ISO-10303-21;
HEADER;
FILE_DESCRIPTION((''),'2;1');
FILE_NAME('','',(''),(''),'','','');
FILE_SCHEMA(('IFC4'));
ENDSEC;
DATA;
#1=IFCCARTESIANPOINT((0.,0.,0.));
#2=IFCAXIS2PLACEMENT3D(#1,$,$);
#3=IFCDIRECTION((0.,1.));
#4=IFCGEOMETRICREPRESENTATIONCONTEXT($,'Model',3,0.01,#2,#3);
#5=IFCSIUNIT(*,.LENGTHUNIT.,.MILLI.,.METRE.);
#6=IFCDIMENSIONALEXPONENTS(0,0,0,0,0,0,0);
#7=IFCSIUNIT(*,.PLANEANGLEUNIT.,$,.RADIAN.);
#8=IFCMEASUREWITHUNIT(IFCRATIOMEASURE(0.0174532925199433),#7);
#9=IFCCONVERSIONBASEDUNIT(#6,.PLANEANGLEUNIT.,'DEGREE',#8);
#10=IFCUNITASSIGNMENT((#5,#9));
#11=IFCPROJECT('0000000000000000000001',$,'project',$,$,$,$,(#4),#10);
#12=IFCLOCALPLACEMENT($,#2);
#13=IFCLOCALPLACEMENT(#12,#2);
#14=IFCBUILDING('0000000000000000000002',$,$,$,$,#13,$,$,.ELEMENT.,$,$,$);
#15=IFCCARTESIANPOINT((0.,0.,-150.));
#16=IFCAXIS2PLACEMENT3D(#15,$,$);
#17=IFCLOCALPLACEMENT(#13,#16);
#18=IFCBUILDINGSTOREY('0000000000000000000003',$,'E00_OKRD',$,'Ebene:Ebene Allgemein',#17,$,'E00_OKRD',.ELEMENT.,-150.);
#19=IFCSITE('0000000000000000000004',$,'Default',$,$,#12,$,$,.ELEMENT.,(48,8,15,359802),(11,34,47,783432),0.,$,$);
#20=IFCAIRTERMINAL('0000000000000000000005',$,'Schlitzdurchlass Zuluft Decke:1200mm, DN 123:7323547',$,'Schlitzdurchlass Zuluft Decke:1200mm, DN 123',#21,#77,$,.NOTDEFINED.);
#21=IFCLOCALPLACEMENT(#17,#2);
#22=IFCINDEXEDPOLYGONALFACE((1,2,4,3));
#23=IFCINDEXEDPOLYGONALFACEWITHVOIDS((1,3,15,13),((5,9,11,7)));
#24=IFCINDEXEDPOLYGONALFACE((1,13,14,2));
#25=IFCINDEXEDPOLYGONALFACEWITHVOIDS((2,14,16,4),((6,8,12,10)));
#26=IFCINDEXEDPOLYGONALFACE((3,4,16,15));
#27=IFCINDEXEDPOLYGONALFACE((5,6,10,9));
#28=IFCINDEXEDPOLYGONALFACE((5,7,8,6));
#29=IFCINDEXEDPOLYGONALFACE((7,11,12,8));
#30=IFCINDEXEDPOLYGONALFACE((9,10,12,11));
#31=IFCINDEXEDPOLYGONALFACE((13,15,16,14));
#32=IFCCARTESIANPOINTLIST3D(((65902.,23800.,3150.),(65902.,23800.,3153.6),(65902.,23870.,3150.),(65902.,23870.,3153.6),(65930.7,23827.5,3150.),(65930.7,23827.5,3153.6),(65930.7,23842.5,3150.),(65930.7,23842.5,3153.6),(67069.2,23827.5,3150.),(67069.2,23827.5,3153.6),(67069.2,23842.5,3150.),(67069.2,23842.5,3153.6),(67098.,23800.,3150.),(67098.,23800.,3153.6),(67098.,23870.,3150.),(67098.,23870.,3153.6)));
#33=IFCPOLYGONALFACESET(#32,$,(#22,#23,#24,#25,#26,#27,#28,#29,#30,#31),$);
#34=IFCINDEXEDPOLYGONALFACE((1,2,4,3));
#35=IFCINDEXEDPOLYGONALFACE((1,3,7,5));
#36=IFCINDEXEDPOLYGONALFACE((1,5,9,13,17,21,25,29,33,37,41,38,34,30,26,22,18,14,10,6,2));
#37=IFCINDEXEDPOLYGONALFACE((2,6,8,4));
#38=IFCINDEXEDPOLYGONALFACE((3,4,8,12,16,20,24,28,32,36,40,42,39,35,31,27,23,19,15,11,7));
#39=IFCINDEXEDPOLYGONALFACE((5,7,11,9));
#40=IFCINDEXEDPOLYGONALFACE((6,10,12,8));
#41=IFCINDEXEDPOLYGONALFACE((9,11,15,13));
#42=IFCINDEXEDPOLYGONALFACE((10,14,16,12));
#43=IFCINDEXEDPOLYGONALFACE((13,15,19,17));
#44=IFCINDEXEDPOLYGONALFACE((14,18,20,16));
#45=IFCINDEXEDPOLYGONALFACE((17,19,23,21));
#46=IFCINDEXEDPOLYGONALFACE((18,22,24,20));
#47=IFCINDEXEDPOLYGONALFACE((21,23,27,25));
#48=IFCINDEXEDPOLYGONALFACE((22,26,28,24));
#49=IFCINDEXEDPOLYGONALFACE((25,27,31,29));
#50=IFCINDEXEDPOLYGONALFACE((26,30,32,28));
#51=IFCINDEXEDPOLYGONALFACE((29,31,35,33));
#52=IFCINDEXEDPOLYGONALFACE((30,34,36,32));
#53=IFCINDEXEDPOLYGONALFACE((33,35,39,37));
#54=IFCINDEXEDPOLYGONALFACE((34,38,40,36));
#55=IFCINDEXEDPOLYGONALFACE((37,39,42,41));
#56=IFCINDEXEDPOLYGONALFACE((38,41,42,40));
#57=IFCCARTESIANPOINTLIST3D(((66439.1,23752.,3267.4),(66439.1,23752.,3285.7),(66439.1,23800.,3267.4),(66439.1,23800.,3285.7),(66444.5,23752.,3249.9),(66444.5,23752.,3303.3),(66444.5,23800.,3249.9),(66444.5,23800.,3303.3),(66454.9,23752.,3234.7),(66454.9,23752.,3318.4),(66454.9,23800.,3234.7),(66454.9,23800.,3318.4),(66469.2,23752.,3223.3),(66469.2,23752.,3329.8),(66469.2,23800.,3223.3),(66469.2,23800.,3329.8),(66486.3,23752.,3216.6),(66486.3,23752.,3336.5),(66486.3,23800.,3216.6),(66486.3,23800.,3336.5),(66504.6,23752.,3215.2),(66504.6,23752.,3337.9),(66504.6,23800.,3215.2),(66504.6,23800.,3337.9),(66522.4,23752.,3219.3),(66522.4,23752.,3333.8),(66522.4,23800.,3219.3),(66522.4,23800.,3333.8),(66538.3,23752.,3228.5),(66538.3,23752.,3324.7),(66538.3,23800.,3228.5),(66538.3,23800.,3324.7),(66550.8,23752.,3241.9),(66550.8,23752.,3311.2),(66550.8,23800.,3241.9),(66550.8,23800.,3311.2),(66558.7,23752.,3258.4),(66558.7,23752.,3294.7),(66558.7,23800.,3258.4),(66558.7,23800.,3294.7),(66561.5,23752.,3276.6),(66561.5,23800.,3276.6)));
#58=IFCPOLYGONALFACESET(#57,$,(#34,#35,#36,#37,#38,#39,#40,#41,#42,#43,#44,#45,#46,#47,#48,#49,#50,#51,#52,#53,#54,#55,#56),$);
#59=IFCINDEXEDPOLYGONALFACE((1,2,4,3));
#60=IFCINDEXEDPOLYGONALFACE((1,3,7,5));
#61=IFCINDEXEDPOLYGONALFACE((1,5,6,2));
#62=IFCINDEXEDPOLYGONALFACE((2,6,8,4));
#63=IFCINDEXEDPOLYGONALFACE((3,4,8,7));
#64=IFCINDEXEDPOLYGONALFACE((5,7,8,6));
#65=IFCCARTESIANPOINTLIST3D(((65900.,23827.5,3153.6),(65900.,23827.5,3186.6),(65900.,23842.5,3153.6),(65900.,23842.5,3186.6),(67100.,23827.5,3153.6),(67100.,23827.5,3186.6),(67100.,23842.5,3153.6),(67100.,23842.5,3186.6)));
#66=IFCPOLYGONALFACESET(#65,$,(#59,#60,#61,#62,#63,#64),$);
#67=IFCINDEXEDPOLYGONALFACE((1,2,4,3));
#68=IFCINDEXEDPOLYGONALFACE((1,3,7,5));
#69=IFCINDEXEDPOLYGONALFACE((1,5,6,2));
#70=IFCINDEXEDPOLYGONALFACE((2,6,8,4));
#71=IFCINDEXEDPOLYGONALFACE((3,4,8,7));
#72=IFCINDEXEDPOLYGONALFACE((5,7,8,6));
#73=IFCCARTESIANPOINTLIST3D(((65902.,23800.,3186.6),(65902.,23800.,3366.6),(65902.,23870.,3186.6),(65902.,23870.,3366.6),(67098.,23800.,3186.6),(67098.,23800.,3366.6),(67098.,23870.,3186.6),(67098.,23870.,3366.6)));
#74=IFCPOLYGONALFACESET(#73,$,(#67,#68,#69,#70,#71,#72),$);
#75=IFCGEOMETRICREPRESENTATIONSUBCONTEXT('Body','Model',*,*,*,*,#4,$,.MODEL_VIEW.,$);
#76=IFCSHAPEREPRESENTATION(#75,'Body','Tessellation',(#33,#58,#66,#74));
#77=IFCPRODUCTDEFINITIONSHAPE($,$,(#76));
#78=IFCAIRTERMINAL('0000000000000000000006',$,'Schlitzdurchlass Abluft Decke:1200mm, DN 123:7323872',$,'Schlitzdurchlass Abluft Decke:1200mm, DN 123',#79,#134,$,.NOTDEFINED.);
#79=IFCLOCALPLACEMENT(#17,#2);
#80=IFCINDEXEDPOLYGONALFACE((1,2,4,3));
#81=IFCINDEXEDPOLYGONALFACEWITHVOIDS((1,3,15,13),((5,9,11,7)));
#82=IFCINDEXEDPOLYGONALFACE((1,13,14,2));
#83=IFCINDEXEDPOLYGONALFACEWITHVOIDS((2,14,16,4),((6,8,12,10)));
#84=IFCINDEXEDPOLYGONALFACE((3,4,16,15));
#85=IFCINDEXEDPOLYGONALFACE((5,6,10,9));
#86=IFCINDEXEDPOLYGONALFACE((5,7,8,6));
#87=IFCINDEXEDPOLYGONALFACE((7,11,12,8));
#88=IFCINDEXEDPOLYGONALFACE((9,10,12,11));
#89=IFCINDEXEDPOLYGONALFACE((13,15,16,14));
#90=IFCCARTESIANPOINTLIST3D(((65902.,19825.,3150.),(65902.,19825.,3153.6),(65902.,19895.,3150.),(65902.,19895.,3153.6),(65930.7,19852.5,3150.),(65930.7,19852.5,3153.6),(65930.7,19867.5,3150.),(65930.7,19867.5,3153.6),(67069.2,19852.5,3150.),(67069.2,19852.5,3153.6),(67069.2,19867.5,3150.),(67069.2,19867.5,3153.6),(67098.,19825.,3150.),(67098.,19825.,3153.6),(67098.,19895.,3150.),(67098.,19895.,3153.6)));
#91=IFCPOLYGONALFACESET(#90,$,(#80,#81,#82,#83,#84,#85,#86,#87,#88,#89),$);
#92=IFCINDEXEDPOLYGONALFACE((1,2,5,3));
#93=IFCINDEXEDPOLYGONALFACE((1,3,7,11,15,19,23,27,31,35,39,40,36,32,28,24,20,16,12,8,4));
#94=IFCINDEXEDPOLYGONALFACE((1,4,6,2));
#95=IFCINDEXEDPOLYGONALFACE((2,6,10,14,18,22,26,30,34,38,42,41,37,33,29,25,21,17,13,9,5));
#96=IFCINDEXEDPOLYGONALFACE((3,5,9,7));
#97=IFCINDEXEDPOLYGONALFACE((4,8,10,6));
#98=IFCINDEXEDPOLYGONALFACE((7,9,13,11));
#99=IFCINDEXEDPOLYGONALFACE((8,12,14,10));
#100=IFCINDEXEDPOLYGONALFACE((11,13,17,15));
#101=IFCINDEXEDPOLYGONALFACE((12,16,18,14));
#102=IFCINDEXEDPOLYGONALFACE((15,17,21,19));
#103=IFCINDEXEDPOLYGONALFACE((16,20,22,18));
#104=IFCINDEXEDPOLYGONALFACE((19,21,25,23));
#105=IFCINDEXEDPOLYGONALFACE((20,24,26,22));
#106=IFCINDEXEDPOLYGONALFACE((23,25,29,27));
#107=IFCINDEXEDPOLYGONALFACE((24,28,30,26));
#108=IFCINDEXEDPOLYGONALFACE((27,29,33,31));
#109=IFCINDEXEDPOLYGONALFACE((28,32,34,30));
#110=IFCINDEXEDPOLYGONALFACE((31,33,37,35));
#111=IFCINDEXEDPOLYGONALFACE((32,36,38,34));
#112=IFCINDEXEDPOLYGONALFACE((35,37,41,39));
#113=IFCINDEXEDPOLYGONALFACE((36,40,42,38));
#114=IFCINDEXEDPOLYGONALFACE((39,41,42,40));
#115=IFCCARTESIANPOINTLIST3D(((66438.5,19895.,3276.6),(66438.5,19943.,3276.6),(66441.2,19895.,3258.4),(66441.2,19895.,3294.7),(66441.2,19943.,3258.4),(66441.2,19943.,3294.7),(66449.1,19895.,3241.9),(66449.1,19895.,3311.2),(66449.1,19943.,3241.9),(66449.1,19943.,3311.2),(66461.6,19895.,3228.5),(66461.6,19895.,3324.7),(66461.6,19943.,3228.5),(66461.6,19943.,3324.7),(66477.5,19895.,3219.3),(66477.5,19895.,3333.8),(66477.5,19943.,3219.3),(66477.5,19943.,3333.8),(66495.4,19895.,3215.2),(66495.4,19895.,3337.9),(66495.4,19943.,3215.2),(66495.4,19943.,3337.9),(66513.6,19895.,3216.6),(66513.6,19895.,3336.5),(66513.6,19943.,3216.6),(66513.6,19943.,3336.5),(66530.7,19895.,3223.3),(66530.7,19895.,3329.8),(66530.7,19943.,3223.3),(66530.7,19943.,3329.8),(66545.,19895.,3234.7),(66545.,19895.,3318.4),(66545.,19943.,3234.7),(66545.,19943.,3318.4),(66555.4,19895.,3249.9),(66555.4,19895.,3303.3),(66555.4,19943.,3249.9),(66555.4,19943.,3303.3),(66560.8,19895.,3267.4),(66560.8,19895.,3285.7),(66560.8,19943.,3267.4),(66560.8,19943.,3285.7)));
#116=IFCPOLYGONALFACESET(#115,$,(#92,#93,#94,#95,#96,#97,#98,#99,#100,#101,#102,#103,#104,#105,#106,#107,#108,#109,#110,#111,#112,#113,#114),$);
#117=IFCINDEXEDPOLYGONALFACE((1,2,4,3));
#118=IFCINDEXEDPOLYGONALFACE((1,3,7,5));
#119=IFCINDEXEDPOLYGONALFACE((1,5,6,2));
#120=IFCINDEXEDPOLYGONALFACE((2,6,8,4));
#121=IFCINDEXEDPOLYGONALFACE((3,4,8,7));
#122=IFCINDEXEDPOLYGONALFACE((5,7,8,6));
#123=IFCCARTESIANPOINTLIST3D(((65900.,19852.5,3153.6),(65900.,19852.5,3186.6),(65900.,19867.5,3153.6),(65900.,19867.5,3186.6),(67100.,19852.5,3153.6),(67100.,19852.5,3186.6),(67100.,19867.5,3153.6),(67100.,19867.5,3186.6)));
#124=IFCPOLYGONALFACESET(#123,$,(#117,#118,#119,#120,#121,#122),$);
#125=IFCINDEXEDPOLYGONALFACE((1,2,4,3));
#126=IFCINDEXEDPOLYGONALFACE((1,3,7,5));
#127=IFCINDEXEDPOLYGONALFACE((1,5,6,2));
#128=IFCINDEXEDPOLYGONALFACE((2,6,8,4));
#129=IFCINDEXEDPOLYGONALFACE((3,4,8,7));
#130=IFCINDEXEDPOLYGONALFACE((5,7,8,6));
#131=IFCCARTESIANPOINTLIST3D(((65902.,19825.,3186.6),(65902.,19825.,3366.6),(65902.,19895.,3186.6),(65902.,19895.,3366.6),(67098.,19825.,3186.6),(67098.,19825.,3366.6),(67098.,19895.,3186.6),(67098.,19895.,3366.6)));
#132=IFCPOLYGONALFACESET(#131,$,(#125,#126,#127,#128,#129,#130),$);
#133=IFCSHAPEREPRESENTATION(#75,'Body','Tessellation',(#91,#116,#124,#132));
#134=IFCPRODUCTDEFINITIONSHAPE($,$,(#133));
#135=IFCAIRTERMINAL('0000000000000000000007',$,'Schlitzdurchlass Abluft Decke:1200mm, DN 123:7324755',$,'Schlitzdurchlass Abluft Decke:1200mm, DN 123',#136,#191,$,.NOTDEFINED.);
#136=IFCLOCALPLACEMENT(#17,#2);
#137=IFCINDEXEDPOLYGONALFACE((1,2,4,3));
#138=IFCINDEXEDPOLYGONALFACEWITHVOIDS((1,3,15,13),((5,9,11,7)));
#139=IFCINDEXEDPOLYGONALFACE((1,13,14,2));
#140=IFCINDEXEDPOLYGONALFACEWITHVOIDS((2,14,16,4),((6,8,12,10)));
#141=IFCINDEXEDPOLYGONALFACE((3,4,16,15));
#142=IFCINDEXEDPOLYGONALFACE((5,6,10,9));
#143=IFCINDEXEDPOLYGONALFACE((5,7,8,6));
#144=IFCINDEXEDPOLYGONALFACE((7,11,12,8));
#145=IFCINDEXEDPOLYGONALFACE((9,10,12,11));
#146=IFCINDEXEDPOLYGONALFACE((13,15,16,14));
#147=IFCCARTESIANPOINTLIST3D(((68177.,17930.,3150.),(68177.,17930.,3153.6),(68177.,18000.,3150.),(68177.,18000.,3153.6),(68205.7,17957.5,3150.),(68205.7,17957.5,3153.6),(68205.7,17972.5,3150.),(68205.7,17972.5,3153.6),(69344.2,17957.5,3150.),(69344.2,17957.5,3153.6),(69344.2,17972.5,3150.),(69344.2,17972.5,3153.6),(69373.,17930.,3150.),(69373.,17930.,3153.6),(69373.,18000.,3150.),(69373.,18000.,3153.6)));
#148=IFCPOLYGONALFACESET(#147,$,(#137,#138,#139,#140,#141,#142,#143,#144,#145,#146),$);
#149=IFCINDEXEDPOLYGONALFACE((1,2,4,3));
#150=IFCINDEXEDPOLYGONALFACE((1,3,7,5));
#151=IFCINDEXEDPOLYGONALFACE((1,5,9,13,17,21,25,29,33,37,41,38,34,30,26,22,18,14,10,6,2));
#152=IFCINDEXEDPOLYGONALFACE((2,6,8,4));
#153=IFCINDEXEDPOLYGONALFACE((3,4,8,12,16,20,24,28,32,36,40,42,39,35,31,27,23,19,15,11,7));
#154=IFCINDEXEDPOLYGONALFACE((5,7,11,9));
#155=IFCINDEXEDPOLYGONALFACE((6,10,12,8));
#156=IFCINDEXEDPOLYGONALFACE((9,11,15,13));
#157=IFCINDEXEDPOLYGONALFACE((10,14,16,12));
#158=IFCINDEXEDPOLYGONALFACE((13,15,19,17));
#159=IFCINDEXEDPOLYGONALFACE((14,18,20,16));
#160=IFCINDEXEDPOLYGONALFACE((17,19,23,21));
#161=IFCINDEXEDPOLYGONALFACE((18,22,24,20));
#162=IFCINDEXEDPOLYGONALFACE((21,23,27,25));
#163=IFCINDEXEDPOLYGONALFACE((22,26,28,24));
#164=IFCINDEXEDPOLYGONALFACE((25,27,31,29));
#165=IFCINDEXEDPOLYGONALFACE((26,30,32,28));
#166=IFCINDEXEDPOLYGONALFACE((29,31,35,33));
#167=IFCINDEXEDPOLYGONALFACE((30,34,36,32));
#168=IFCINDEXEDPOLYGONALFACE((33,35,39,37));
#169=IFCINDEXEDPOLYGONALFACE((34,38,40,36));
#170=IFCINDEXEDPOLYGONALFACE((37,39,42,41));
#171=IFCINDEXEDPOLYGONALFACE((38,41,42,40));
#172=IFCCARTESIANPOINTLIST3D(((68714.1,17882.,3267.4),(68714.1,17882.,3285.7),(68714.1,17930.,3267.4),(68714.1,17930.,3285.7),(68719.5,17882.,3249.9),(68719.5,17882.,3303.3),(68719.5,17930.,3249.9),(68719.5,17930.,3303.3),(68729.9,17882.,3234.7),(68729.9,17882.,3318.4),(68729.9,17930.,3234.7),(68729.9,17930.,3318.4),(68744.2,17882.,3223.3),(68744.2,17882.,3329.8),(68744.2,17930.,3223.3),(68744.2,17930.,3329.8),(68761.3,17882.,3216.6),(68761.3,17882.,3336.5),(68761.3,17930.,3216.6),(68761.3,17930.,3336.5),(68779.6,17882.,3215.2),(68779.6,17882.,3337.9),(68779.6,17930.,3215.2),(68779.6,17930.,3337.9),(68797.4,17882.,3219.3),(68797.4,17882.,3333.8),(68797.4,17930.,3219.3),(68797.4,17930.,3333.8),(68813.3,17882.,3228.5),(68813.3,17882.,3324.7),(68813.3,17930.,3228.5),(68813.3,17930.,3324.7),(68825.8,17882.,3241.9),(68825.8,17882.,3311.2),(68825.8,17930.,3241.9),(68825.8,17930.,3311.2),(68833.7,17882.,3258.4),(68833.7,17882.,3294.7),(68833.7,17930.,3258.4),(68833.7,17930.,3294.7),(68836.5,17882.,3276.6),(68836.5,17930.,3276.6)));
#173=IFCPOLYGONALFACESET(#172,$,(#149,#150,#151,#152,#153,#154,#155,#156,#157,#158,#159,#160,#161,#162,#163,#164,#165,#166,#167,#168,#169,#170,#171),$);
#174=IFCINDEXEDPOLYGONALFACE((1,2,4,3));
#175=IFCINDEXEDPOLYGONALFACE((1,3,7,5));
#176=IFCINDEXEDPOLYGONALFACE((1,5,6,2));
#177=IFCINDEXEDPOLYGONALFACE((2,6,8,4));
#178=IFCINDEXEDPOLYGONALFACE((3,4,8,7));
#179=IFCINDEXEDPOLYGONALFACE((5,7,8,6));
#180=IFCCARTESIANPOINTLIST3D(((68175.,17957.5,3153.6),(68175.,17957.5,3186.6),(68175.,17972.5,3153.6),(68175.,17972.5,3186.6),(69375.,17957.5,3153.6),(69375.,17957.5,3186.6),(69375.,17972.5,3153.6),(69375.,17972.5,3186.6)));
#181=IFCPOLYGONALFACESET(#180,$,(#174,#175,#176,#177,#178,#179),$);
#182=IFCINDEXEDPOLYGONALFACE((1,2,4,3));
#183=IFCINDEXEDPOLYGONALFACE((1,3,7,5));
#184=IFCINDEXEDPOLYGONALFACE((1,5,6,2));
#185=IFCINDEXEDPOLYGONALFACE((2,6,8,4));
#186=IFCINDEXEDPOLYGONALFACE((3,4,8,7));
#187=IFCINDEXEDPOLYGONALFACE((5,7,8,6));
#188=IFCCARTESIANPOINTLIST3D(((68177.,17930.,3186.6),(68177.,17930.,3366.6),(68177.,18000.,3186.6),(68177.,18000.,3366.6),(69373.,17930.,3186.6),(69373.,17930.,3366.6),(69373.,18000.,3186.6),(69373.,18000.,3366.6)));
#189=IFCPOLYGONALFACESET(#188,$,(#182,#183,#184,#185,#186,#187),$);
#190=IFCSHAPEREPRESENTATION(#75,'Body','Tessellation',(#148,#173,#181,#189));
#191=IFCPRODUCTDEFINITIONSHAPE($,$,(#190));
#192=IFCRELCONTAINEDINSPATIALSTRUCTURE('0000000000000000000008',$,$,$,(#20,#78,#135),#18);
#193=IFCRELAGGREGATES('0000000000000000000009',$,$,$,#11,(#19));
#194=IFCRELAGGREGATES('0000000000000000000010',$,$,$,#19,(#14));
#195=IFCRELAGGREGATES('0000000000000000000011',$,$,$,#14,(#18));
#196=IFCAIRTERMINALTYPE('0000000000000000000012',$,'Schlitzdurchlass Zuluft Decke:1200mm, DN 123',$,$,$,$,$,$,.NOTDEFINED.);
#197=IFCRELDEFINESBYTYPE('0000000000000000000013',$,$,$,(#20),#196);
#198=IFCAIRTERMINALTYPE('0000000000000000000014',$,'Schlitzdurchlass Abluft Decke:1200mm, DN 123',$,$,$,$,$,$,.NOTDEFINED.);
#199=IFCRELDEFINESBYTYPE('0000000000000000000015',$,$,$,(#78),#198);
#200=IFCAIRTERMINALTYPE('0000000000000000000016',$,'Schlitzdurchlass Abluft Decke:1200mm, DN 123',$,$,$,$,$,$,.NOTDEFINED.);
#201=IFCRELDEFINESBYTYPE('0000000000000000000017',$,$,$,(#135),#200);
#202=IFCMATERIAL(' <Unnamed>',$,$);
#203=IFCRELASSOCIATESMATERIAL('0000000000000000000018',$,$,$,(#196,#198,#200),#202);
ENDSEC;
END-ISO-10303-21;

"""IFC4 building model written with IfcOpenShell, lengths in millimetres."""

from ifc_helpers import new_model, entity, si_unit, converted_unit, direction, frame, frame_2d, origin, origin_2d_with_axis, place, context, subcontext, project, spatial, polyline, rectangle, circle, outline, extrude, source, transform, mapped, material, type_object, type_shapes, element, save


model = new_model("IFC4")

# Units and contexts
model_context = context("Model", 3, precision=0.01, world=origin(), true_north=direction((0.0, 1.0)))
body_context = subcontext(model_context, "Body", "Model", "MODEL_VIEW")
ifc_project = project(units=[si_unit("LENGTHUNIT", "METRE", prefix="MILLI"), converted_unit("PLANEANGLEUNIT", "DEGREE", entity("IfcRatioMeasure", 0.0174532925199433), si_unit("PLANEANGLEUNIT", "RADIAN"), dimensions=[0, 0, 0, 0, 0, 0, 0])], contexts=[model_context])

# Site, building, storey
site_placement = place(None, origin())
site = spatial("IfcSite", under=ifc_project, at=site_placement, Name="Default", CompositionType="ELEMENT", RefLatitude=(48, 8, 15, 359802), RefLongitude=(11, 34, 47, 783432), RefElevation=0.0)
building_placement = place(site_placement, origin())
building = spatial("IfcBuilding", under=site, at=building_placement, CompositionType="ELEMENT")
storey_placement = place(building_placement, frame((0.0, 0.0, -150.0)))
storey = spatial("IfcBuildingStorey", under=building, at=storey_placement, Name="E00_OKRD", ObjectType="Ebene:Ebene Allgemein", LongName="E00_OKRD", CompositionType="ELEMENT", Elevation=-150.0)

# Air terminals
ifc_material_1 = material(Name=" <Unnamed>")
air_terminal_type_1 = type_object("IfcAirTerminalType", Name="Schlitzdurchlass Zuluft Decke:1200mm, DN 123", PredefinedType="NOTDEFINED", material=ifc_material_1)
shared_shape_1 = source(origin(), body_context, "Body", "SweptSolid", [
    extrude(outline(polyline([(-598.0, -35.0), (598.0, -35.0), (598.0, 35.0), (-598.0, 35.0), (-598.0, -35.0)]), holes=[polyline([(-569.2, -7.5), (-569.2, 7.5), (569.2, 7.5), (569.2, -7.5), (-569.2, -7.5)])]), frame((600.0, 35.0, 0.0), z_axis=(0.0, 0.0, 1.0), x_axis=(-1.0, 0.0, 0.0)), (0.0, 0.0, 1.0), 3.6),
    extrude(circle(Radius=61.5, at=frame_2d((0.0, 0.0), x_axis=(1.0, 0.0))), frame((600.0, 70.0, 126.6), z_axis=(0.0, 1.0, 0.0), x_axis=(-1.0, 0.0, 0.0)), (0.0, 0.0, 1.0), 48.0),
    extrude(rectangle(XDim=1200.0, YDim=15.0, at=origin_2d_with_axis()), frame((600.0, 35.0, 3.6), z_axis=(0.0, 0.0, 1.0), x_axis=(-1.0, 0.0, 0.0)), (0.0, 0.0, 1.0), 33.0),
    extrude(rectangle(XDim=1196.0, YDim=70.0, at=origin_2d_with_axis()), frame((600.0, 35.0, 36.6), z_axis=(0.0, 0.0, 1.0), x_axis=(-1.0, 0.0, 0.0)), (0.0, 0.0, 1.0), 180.0),
])
type_shapes(air_terminal_type_1, [shared_shape_1])
air_terminal_1_placement = place(storey_placement, frame((67100.0, 23870.0, 3150.0), z_axis=(0.0, 0.0, 1.0), x_axis=(-1.0, 0.0, 0.0)))
element("IfcAirTerminal", 1, at=air_terminal_1_placement, inside=storey, type_object=air_terminal_type_1, Name="Schlitzdurchlass Zuluft Decke:1200mm, DN 123:7323547", ObjectType="Schlitzdurchlass Zuluft Decke:1200mm, DN 123", PredefinedType="NOTDEFINED", context=body_context, shape_type="MappedRepresentation", body=[
    mapped(shared_shape_1, transform((0.0, 0.0, 0.0), scale=1.0)),
])
air_terminal_type_2 = type_object("IfcAirTerminalType", Name="Schlitzdurchlass Abluft Decke:1200mm, DN 123", PredefinedType="NOTDEFINED", material=ifc_material_1)
shared_shape_2 = source(origin(), body_context, "Body", "SweptSolid", [
    extrude(outline(polyline([(-598.0, -35.0), (598.0, -35.0), (598.0, 35.0), (-598.0, 35.0), (-598.0, -35.0)]), holes=[polyline([(-569.2, -7.5), (-569.2, 7.5), (569.2, 7.5), (569.2, -7.5), (-569.2, -7.5)])]), frame((0.0, 0.0, 0.0), z_axis=(0.0, 0.0, 1.0), x_axis=(-1.0, 0.0, 0.0)), (0.0, 0.0, 1.0), 3.6),
    extrude(circle(Radius=61.5, at=frame_2d((0.0, 0.0), x_axis=(1.0, 0.0))), frame((0.0, 35.0, 126.6), z_axis=(0.0, 1.0, 0.0), x_axis=(-1.0, 0.0, 0.0)), (0.0, 0.0, 1.0), 48.0),
    extrude(rectangle(XDim=1200.0, YDim=15.0, at=origin_2d_with_axis()), frame((0.0, 0.0, 3.6), z_axis=(0.0, 0.0, 1.0), x_axis=(-1.0, 0.0, 0.0)), (0.0, 0.0, 1.0), 33.0),
    extrude(rectangle(XDim=1196.0, YDim=70.0, at=origin_2d_with_axis()), frame((0.0, 0.0, 36.6), z_axis=(0.0, 0.0, 1.0), x_axis=(-1.0, 0.0, 0.0)), (0.0, 0.0, 1.0), 180.0),
])
type_shapes(air_terminal_type_2, [shared_shape_2])
air_terminal_2_placement = place(storey_placement, frame((66500.0, 19860.0, 3150.0)))
element("IfcAirTerminal", 2, at=air_terminal_2_placement, inside=storey, type_object=air_terminal_type_2, Name="Schlitzdurchlass Abluft Decke:1200mm, DN 123:7323872", ObjectType="Schlitzdurchlass Abluft Decke:1200mm, DN 123", PredefinedType="NOTDEFINED", context=body_context, shape_type="MappedRepresentation", body=[
    mapped(shared_shape_2, transform((0.0, 0.0, 0.0), scale=1.0)),
])
air_terminal_type_3 = type_object("IfcAirTerminalType", Name="Schlitzdurchlass Abluft Decke:1200mm, DN 123", PredefinedType="NOTDEFINED", material=ifc_material_1)
shared_shape_3 = source(origin(), body_context, "Body", "SweptSolid", [
    extrude(outline(polyline([(-598.0, -35.0), (598.0, -35.0), (598.0, 35.0), (-598.0, 35.0), (-598.0, -35.0)]), holes=[polyline([(-569.2, -7.5), (-569.2, 7.5), (569.2, 7.5), (569.2, -7.5), (-569.2, -7.5)])]), frame((0.0, 0.0, 0.0), z_axis=(0.0, 0.0, 1.0), x_axis=(-1.0, 0.0, 0.0)), (0.0, 0.0, 1.0), 3.6),
    extrude(circle(Radius=61.5, at=frame_2d((0.0, 0.0), x_axis=(1.0, 0.0))), frame((0.0, 35.0, 126.6), z_axis=(0.0, 1.0, 0.0), x_axis=(-1.0, 0.0, 0.0)), (0.0, 0.0, 1.0), 48.0),
    extrude(rectangle(XDim=1200.0, YDim=15.0, at=origin_2d_with_axis()), frame((0.0, 0.0, 3.6), z_axis=(0.0, 0.0, 1.0), x_axis=(-1.0, 0.0, 0.0)), (0.0, 0.0, 1.0), 33.0),
    extrude(rectangle(XDim=1196.0, YDim=70.0, at=origin_2d_with_axis()), frame((0.0, 0.0, 36.6), z_axis=(0.0, 0.0, 1.0), x_axis=(-1.0, 0.0, 0.0)), (0.0, 0.0, 1.0), 180.0),
])
type_shapes(air_terminal_type_3, [shared_shape_3])
for number, where, z_axis, x_axis, name in (
    (3, (68775.0, 17965.0, 3150.0), (0.0, 0.0, 1.0), (-1.0, 0.0, 0.0), "Schlitzdurchlass Abluft Decke:1200mm, DN 123:7324755"),
):
    element("IfcAirTerminal", number, at=place(storey_placement, frame(where, z_axis=z_axis, x_axis=x_axis)), inside=storey, type_object=air_terminal_type_3, Name=name, ObjectType="Schlitzdurchlass Abluft Decke:1200mm, DN 123", PredefinedType="NOTDEFINED", context=body_context, shape_type="MappedRepresentation", body=[
        mapped(shared_shape_3, transform((0.0, 0.0, 0.0), scale=1.0)),
    ])

save(model, "model.ifc")
